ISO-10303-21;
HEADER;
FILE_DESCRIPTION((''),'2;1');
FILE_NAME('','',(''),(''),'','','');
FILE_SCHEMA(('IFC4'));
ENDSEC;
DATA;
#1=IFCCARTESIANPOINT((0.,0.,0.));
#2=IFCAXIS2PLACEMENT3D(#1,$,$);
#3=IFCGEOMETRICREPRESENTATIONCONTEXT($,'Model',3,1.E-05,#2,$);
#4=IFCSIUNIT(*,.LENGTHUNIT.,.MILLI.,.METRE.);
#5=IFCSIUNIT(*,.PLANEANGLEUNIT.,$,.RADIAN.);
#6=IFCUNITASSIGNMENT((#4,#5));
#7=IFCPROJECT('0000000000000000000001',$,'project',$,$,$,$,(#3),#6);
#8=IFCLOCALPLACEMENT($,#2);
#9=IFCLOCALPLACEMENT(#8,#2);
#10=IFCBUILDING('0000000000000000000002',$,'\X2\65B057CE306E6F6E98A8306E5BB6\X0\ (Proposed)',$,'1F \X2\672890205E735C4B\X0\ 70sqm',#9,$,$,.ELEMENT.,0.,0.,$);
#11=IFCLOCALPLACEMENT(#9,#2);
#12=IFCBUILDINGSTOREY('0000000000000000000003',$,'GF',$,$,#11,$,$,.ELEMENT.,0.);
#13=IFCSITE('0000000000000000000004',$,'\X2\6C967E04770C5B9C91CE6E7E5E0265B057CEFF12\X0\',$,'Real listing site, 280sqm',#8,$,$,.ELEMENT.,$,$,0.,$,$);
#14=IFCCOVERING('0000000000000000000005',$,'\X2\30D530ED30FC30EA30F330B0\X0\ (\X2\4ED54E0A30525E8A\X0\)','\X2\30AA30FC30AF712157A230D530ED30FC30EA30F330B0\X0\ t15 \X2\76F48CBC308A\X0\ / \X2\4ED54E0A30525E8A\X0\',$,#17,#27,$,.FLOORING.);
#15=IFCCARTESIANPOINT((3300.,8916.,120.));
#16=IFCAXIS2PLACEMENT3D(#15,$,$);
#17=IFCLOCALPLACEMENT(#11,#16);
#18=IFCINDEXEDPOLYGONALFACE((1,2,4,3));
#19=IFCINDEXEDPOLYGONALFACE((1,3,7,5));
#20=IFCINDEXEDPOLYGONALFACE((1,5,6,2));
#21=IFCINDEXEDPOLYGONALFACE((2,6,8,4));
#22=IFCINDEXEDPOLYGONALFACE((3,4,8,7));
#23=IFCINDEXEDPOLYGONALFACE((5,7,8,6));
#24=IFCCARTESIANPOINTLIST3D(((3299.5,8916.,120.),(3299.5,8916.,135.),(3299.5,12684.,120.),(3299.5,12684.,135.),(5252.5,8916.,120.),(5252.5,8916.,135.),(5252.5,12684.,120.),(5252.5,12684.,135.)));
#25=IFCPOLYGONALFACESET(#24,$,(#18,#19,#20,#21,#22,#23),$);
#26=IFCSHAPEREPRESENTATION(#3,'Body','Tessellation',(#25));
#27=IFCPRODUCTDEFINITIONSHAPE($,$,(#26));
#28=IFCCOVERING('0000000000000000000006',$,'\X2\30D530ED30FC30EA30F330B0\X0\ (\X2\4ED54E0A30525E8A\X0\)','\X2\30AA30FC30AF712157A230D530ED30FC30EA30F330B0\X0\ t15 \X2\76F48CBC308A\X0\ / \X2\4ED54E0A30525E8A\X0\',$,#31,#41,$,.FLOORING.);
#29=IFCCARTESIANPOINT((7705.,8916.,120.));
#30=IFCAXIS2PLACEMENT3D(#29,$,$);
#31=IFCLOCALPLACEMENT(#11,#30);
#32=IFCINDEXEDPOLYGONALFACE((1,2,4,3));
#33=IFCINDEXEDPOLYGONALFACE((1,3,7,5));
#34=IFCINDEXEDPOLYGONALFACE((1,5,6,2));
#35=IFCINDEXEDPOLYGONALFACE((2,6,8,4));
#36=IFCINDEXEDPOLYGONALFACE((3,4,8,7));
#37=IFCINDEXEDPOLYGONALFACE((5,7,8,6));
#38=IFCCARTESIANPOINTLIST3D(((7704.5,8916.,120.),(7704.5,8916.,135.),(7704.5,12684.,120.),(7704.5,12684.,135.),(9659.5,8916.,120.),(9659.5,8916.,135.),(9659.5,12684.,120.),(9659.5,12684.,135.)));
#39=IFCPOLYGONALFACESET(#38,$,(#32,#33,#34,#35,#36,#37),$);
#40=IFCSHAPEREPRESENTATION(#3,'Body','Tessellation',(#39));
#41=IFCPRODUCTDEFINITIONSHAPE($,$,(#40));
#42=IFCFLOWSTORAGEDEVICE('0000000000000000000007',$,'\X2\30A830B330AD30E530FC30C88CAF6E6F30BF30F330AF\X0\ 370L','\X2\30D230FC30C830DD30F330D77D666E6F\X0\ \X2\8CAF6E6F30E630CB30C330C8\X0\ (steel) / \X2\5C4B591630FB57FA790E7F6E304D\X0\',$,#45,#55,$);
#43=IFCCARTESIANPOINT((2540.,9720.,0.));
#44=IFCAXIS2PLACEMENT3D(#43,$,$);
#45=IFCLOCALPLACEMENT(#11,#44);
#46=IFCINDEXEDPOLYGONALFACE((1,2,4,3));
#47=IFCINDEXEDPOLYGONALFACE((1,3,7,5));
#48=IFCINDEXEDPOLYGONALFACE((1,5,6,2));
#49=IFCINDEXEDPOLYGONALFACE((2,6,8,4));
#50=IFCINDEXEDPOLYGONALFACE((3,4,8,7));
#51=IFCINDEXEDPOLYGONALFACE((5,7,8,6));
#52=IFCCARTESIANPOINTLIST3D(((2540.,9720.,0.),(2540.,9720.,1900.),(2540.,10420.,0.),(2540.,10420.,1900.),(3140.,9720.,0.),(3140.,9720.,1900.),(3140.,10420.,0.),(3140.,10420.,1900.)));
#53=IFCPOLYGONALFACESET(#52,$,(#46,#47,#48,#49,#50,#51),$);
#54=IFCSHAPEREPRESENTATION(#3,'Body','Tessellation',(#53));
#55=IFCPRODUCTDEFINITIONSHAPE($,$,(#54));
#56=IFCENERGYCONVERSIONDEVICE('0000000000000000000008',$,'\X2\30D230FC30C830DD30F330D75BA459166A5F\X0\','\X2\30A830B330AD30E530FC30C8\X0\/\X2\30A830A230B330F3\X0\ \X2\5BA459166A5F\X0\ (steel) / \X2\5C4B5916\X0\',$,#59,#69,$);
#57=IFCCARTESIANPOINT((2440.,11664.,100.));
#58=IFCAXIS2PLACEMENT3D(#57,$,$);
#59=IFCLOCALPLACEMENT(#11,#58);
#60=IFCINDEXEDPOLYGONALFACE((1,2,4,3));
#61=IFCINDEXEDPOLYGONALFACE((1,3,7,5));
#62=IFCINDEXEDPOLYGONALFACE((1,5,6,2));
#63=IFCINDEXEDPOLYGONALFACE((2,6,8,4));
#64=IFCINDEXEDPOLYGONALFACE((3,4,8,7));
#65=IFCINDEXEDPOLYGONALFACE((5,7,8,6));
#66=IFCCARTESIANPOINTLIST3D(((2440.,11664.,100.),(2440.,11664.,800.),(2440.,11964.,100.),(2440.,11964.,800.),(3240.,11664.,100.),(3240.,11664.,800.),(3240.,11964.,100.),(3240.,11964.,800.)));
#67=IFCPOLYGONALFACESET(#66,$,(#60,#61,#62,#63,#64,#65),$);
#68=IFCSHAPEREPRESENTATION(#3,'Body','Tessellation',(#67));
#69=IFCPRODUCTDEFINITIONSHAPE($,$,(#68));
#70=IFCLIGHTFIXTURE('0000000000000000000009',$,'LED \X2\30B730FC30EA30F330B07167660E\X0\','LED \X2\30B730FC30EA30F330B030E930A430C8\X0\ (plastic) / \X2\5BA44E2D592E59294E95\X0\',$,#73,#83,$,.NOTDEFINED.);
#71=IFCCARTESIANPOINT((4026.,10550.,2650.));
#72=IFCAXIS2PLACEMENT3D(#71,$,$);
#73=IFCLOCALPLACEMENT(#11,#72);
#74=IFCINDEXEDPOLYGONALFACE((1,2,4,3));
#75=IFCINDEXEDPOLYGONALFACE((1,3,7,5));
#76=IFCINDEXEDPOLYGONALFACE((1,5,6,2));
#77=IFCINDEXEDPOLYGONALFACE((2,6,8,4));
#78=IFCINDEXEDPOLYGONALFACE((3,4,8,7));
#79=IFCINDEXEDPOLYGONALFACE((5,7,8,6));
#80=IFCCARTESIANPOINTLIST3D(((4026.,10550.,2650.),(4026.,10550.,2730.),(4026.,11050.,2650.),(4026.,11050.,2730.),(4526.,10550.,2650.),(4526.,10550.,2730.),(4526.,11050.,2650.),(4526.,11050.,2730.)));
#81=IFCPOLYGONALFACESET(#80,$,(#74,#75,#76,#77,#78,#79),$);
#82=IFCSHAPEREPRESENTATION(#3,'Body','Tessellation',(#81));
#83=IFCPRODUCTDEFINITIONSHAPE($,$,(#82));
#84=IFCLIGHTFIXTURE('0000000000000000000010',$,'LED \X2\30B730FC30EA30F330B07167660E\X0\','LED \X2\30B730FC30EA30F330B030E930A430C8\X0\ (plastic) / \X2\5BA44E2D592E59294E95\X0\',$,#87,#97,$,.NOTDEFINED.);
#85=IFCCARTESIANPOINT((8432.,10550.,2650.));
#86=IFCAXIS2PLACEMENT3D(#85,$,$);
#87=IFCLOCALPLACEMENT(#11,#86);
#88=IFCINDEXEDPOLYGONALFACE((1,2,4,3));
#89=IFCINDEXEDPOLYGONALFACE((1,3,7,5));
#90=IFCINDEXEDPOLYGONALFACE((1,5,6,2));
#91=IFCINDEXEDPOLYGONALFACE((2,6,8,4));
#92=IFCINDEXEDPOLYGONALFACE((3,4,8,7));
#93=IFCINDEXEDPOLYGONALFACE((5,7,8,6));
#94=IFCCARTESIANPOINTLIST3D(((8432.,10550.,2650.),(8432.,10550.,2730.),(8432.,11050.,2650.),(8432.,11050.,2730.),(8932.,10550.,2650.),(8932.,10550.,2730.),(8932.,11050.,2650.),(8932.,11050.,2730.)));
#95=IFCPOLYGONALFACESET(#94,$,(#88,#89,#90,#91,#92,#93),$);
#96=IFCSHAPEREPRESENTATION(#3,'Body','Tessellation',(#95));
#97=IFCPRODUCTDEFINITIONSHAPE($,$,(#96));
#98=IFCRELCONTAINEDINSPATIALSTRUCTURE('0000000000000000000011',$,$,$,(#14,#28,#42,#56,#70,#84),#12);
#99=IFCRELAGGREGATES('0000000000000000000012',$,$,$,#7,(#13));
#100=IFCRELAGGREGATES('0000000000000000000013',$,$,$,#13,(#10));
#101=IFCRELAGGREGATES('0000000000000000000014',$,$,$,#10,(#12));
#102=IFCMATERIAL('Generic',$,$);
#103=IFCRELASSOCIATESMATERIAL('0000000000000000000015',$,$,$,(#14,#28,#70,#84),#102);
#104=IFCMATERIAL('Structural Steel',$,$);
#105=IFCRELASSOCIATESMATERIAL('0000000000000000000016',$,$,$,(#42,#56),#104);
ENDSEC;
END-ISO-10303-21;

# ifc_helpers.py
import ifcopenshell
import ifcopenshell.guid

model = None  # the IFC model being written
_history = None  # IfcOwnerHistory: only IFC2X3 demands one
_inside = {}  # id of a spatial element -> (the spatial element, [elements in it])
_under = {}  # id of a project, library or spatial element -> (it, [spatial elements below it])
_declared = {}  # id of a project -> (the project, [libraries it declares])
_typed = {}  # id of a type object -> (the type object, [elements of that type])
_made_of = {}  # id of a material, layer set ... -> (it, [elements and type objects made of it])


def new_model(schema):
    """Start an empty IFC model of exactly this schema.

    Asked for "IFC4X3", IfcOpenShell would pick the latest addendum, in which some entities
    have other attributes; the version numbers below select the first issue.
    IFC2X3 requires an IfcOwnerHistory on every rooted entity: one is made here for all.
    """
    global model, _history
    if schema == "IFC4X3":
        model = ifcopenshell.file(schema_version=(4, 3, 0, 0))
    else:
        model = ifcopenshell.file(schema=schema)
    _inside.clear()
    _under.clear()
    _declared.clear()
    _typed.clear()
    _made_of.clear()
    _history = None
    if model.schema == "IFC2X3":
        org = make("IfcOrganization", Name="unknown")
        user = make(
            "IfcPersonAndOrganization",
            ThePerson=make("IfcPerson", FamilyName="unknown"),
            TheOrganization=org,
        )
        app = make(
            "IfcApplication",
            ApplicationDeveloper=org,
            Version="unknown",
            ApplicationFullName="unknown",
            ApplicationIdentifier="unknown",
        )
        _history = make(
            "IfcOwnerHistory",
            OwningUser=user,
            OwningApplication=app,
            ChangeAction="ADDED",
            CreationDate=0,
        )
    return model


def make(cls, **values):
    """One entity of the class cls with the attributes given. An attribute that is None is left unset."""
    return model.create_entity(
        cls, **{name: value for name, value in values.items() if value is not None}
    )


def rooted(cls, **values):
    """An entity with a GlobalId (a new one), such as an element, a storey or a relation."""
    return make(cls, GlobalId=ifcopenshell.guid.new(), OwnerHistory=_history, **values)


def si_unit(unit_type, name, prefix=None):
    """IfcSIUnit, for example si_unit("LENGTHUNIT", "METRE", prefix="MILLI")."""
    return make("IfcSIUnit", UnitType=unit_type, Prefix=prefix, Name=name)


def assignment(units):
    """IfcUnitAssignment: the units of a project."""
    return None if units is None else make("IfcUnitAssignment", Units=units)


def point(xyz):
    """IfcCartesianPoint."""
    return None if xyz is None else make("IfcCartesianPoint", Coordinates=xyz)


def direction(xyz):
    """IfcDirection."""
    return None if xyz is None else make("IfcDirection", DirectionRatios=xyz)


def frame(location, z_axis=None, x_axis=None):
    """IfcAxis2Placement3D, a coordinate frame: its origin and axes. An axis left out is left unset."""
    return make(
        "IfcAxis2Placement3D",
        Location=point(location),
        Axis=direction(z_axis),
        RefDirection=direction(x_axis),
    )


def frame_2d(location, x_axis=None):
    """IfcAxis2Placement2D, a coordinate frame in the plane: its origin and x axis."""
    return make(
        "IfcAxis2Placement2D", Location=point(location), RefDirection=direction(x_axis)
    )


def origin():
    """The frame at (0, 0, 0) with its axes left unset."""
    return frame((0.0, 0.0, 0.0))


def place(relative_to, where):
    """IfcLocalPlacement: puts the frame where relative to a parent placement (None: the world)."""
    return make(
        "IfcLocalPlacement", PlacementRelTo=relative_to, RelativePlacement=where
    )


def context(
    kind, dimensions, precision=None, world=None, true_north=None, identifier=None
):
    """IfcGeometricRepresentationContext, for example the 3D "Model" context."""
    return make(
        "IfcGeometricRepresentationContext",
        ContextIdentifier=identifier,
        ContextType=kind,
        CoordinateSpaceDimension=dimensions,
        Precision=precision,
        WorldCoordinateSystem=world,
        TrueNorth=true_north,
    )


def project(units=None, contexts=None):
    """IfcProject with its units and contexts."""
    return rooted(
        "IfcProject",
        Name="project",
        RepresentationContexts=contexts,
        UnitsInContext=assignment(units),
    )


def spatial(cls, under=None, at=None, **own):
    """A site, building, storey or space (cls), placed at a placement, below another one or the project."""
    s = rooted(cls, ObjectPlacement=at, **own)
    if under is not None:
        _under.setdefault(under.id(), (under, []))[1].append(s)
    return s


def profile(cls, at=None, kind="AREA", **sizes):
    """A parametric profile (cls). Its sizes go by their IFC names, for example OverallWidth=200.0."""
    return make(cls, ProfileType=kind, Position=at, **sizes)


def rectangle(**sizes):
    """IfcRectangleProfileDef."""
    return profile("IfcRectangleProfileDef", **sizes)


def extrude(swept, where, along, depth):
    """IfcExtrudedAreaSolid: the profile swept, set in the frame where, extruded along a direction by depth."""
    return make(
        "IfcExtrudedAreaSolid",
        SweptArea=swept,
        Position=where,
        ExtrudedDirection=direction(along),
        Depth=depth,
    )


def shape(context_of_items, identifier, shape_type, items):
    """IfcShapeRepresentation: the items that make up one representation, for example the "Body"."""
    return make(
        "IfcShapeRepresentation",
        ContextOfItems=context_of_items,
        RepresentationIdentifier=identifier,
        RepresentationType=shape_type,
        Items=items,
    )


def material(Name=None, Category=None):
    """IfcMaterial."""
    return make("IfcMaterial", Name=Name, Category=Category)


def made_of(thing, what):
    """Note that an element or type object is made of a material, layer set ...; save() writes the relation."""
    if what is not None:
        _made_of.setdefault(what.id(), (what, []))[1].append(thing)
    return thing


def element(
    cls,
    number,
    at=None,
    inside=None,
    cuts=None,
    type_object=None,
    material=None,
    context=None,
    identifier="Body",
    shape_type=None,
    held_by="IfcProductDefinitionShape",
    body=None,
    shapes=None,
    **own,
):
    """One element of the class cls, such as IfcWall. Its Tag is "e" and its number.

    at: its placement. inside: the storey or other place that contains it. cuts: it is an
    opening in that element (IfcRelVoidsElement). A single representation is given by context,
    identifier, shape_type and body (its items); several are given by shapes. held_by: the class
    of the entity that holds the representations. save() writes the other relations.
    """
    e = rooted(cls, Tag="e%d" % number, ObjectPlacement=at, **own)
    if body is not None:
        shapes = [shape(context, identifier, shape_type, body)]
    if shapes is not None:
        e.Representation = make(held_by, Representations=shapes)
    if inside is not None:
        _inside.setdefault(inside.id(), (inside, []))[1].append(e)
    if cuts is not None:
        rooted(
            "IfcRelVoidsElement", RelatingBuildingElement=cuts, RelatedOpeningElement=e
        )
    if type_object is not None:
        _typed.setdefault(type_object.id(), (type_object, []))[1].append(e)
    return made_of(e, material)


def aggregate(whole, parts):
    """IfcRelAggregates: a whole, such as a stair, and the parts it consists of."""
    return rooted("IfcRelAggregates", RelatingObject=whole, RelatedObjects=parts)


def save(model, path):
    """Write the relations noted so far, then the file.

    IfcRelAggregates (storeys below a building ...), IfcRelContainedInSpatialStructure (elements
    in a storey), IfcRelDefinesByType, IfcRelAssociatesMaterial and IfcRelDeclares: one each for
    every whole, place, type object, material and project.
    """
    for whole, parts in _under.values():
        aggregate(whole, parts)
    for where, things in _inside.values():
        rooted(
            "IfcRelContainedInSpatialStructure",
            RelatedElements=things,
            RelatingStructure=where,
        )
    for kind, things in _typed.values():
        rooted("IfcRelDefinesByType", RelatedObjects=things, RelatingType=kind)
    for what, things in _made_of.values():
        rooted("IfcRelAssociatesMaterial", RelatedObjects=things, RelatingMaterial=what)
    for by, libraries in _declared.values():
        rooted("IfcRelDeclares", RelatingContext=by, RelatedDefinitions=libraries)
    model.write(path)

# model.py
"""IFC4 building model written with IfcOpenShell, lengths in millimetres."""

from ifc_helpers import new_model, si_unit, frame, frame_2d, origin, place, context, project, spatial, rectangle, extrude, material, element, save


model = new_model("IFC4")

# Units and contexts
model_context = context("Model", 3, precision=1e-05, world=origin())
ifc_project = project(units=[si_unit("LENGTHUNIT", "METRE", prefix="MILLI"), si_unit("PLANEANGLEUNIT", "RADIAN")], contexts=[model_context])

# Site, building, storey
site_placement = place(None, origin())
site = spatial("IfcSite", under=ifc_project, at=site_placement, Name="沖縄県宜野湾市新城２", ObjectType="Real listing site, 280sqm", CompositionType="ELEMENT", RefElevation=0.0)
building_placement = place(site_placement, origin())
building = spatial("IfcBuilding", under=site, at=building_placement, Name="新城の潮風の家 (Proposed)", ObjectType="1F 木造平屋 70sqm", CompositionType="ELEMENT", ElevationOfRefHeight=0.0, ElevationOfTerrain=0.0)
storey_placement = place(building_placement, origin())
storey = spatial("IfcBuildingStorey", under=building, at=storey_placement, Name="GF", CompositionType="ELEMENT", Elevation=0.0)

# Shared definitions
ifc_material_1 = material(Name="Structural Steel")

# Coverings
ifc_material_2 = material(Name="Generic")
covering_1_placement = place(storey_placement, frame((3300.0, 8916.0, 120.0)))
element("IfcCovering", 1, at=covering_1_placement, inside=storey, material=ifc_material_2, Name="フローリング (仕上げ床)", Description="オーク無垢フローリング t15 直貼り / 仕上げ床", PredefinedType="FLOORING", context=model_context, shape_type="SweptSolid", body=[
    extrude(rectangle(XDim=1953.0, YDim=3768.0, at=frame_2d((976.0, 1884.0))), frame((3300.0, 8916.0, 120.0)), (0.0, 0.0, 1.0), 15.0),
])
covering_2_placement = place(storey_placement, frame((7705.0, 8916.0, 120.0)))
element("IfcCovering", 2, at=covering_2_placement, inside=storey, material=ifc_material_2, Name="フローリング (仕上げ床)", Description="オーク無垢フローリング t15 直貼り / 仕上げ床", PredefinedType="FLOORING", context=model_context, shape_type="SweptSolid", body=[
    extrude(rectangle(XDim=1955.0, YDim=3768.0, at=frame_2d((977.0, 1884.0))), frame((7705.0, 8916.0, 120.0)), (0.0, 0.0, 1.0), 15.0),
])

# Flow storage device
flow_storage_device_placement = place(storey_placement, frame((2540.0, 9720.0, 0.0)))
element("IfcFlowStorageDevice", 3, at=flow_storage_device_placement, inside=storey, material=ifc_material_1, Name="エコキュート貯湯タンク 370L", Description="ヒートポンプ給湯 貯湯ユニット (steel) / 屋外・基礎置き", context=model_context, shape_type="SweptSolid", body=[
    extrude(rectangle(XDim=600.0, YDim=700.0, at=frame_2d((300.0, 350.0))), frame((2540.0, 9720.0, 0.0)), (0.0, 0.0, 1.0), 1900.0),
])

# Energy conversion device
energy_conversion_device_placement = place(storey_placement, frame((2440.0, 11664.0, 100.0)))
element("IfcEnergyConversionDevice", 4, at=energy_conversion_device_placement, inside=storey, material=ifc_material_1, Name="ヒートポンプ室外機", Description="エコキュート/エアコン 室外機 (steel) / 屋外", context=model_context, shape_type="SweptSolid", body=[
    extrude(rectangle(XDim=800.0, YDim=300.0, at=frame_2d((400.0, 150.0))), frame((2440.0, 11664.0, 100.0)), (0.0, 0.0, 1.0), 700.0),
])

# Light fixtures
light_fixture_1_placement = place(storey_placement, frame((4026.0, 10550.0, 2650.0)))
element("IfcLightFixture", 5, at=light_fixture_1_placement, inside=storey, material=ifc_material_2, Name="LED シーリング照明", Description="LED シーリングライト (plastic) / 室中央天井", PredefinedType="NOTDEFINED", context=model_context, shape_type="SweptSolid", body=[
    extrude(rectangle(XDim=500.0, YDim=500.0, at=frame_2d((250.0, 250.0))), frame((4026.0, 10550.0, 2650.0)), (0.0, 0.0, 1.0), 80.0),
])
light_fixture_2_placement = place(storey_placement, frame((8432.0, 10550.0, 2650.0)))
element("IfcLightFixture", 6, at=light_fixture_2_placement, inside=storey, material=ifc_material_2, Name="LED シーリング照明", Description="LED シーリングライト (plastic) / 室中央天井", PredefinedType="NOTDEFINED", context=model_context, shape_type="SweptSolid", body=[
    extrude(rectangle(XDim=500.0, YDim=500.0, at=frame_2d((250.0, 250.0))), frame((8432.0, 10550.0, 2650.0)), (0.0, 0.0, 1.0), 80.0),
])

save(model, "model.ifc")
